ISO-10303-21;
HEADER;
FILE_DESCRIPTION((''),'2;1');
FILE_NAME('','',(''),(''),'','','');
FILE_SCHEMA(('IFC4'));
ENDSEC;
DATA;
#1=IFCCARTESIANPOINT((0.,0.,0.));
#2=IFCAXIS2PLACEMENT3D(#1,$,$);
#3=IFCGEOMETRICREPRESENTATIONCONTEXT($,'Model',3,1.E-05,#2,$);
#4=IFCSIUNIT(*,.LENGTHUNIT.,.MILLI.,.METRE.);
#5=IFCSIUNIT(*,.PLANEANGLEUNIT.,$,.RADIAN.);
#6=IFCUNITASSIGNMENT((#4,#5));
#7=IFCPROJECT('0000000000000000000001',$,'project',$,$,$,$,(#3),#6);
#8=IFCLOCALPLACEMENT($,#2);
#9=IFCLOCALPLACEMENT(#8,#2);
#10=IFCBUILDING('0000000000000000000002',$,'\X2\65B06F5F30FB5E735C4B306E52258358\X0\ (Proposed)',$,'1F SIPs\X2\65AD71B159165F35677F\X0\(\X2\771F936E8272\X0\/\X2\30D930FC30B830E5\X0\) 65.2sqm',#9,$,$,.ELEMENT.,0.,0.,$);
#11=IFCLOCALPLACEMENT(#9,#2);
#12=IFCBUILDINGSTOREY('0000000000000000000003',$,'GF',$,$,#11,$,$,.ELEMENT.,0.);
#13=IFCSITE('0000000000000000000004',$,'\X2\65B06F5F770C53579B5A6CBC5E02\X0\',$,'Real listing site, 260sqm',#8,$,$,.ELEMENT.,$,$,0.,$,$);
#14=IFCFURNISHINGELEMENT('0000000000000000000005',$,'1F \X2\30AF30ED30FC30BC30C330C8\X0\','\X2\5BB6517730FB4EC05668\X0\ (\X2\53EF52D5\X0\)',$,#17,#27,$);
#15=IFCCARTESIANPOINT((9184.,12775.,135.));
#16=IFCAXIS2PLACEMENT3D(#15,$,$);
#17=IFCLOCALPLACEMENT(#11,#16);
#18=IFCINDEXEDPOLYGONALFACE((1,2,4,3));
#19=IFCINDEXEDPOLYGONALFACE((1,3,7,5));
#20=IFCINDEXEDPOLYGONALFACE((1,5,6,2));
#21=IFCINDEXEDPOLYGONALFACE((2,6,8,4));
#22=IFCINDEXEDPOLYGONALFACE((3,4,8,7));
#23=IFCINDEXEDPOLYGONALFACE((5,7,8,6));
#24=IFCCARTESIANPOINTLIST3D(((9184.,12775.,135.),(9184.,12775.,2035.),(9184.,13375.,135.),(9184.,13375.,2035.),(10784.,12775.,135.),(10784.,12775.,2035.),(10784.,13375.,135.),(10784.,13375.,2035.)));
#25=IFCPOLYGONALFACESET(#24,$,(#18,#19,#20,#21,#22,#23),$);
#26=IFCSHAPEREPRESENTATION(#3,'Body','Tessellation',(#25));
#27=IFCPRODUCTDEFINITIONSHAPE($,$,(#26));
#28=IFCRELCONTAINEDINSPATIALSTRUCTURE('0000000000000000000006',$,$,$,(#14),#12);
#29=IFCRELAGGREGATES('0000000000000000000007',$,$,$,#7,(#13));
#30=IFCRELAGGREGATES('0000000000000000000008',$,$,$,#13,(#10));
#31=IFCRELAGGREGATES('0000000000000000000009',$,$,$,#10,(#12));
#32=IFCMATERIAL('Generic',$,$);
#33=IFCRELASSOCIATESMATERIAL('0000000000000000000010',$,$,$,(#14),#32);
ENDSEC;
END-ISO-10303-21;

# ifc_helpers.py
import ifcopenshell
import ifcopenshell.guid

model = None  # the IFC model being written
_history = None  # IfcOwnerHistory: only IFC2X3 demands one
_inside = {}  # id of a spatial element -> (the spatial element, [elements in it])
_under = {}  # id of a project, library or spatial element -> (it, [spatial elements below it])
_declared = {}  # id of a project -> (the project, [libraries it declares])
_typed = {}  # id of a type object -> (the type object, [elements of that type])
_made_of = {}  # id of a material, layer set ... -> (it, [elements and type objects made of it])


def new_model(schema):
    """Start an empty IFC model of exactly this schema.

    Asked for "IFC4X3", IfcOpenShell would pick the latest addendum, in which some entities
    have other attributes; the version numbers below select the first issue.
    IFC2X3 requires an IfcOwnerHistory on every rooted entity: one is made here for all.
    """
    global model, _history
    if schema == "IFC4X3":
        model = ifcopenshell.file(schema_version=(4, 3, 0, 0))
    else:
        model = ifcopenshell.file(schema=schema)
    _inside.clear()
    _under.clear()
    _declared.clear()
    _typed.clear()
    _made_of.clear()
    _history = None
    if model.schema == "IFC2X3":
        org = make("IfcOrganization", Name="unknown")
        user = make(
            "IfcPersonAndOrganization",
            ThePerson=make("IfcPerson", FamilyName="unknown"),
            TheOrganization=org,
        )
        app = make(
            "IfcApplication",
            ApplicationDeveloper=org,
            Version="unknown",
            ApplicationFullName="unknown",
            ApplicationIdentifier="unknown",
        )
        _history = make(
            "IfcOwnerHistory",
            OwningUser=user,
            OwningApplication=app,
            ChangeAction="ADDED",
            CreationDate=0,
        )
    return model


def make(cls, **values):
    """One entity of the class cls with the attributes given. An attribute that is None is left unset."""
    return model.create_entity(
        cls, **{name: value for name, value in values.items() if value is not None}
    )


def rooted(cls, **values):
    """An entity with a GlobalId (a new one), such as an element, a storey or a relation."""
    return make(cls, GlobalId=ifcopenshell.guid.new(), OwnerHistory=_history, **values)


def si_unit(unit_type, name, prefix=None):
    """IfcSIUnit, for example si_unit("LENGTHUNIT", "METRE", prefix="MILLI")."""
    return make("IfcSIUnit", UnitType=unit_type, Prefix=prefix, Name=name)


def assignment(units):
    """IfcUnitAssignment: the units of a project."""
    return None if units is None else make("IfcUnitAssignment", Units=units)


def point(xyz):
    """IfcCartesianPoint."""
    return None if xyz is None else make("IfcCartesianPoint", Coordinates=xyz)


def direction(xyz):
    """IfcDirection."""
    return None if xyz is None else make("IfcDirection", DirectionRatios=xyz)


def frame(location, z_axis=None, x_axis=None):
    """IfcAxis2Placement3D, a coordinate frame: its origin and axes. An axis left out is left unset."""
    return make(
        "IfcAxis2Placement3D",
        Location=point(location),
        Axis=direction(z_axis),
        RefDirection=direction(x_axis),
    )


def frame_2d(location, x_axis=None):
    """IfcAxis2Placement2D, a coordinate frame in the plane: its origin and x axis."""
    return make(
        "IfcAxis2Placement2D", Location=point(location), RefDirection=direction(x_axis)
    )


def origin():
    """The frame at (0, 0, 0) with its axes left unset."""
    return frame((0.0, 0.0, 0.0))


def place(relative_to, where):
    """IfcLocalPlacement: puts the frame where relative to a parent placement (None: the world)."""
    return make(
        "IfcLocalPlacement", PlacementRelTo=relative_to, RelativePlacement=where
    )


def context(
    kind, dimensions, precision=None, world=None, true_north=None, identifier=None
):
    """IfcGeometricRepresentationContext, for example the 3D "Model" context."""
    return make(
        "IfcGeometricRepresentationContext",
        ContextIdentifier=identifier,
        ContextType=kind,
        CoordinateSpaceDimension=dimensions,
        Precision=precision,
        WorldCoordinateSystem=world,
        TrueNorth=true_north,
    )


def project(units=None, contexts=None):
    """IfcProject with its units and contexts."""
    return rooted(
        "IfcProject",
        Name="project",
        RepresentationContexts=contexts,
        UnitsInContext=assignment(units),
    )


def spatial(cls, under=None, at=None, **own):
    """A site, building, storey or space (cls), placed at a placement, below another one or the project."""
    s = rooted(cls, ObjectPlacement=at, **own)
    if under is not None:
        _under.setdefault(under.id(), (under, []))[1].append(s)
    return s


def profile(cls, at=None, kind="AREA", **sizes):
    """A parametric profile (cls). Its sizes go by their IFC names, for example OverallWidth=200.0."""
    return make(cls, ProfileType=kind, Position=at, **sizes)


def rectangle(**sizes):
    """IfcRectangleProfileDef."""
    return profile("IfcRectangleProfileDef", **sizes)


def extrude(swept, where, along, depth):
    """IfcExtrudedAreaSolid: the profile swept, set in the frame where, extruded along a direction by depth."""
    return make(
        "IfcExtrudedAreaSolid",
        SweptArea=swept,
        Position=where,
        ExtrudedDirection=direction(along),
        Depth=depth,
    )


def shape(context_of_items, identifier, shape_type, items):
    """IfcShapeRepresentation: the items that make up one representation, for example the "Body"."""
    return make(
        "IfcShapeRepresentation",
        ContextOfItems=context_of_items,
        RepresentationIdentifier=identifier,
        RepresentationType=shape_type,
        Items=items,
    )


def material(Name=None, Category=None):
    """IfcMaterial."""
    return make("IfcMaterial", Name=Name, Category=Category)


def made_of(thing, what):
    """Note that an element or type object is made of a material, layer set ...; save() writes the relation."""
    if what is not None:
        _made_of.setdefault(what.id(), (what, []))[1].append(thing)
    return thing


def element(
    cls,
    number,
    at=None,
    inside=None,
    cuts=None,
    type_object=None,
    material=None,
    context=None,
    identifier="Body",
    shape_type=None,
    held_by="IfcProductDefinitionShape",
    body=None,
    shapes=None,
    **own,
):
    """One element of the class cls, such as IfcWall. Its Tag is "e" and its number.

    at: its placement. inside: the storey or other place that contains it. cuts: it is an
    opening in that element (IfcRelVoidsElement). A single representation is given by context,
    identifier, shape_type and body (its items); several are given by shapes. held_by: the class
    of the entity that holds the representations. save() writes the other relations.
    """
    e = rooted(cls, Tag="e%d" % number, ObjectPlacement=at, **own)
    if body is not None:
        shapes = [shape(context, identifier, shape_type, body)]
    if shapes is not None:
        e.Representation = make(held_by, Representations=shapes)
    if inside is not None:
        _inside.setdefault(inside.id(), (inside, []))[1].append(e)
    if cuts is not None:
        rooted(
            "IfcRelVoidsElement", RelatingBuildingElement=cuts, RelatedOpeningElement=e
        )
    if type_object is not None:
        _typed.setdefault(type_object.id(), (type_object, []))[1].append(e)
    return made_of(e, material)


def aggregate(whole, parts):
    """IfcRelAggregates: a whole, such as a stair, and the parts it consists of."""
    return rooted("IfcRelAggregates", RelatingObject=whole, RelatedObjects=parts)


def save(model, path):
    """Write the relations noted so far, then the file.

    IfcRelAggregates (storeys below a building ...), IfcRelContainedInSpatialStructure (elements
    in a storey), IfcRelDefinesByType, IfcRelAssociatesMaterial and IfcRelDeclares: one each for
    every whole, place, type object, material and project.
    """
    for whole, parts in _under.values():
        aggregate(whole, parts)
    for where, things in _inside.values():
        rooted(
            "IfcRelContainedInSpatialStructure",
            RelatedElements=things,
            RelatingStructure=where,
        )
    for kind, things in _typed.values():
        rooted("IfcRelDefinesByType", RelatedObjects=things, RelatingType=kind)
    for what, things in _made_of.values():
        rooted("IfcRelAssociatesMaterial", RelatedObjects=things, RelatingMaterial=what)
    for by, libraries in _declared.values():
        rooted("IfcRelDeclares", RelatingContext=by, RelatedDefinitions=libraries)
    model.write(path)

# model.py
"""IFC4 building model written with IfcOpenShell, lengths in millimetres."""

from ifc_helpers import new_model, si_unit, frame, frame_2d, origin, place, context, project, spatial, rectangle, extrude, material, element, save


model = new_model("IFC4")

# Units and contexts
model_context = context("Model", 3, precision=1e-05, world=origin())
ifc_project = project(units=[si_unit("LENGTHUNIT", "METRE", prefix="MILLI"), si_unit("PLANEANGLEUNIT", "RADIAN")], contexts=[model_context])

# Site, building, storey
site_placement = place(None, origin())
site = spatial("IfcSite", under=ifc_project, at=site_placement, Name="新潟県南魚沼市", ObjectType="Real listing site, 260sqm", CompositionType="ELEMENT", RefElevation=0.0)
building_placement = place(site_placement, origin())
building = spatial("IfcBuilding", under=site, at=building_placement, Name="新潟・平屋の別荘 (Proposed)", ObjectType="1F SIPs断熱外張板(真鍮色/ベージュ) 65.2sqm", CompositionType="ELEMENT", ElevationOfRefHeight=0.0, ElevationOfTerrain=0.0)
storey_placement = place(building_placement, origin())
storey = spatial("IfcBuildingStorey", under=building, at=storey_placement, Name="GF", CompositionType="ELEMENT", Elevation=0.0)

# Shared definitions
ifc_material_1 = material(Name="Generic")

# Furnishing element
furnishing_placement = place(storey_placement, frame((9184.0, 12775.0, 135.0)))
element("IfcFurnishingElement", 1, at=furnishing_placement, inside=storey, material=ifc_material_1, Name="1F クローゼット", Description="家具・什器 (可動)", context=model_context, shape_type="SweptSolid", body=[
    extrude(rectangle(XDim=1600.0, YDim=600.0, at=frame_2d((800.0, 300.0))), frame((9184.0, 12775.0, 135.0)), (0.0, 0.0, 1.0), 1900.0),
])

save(model, "model.ifc")
